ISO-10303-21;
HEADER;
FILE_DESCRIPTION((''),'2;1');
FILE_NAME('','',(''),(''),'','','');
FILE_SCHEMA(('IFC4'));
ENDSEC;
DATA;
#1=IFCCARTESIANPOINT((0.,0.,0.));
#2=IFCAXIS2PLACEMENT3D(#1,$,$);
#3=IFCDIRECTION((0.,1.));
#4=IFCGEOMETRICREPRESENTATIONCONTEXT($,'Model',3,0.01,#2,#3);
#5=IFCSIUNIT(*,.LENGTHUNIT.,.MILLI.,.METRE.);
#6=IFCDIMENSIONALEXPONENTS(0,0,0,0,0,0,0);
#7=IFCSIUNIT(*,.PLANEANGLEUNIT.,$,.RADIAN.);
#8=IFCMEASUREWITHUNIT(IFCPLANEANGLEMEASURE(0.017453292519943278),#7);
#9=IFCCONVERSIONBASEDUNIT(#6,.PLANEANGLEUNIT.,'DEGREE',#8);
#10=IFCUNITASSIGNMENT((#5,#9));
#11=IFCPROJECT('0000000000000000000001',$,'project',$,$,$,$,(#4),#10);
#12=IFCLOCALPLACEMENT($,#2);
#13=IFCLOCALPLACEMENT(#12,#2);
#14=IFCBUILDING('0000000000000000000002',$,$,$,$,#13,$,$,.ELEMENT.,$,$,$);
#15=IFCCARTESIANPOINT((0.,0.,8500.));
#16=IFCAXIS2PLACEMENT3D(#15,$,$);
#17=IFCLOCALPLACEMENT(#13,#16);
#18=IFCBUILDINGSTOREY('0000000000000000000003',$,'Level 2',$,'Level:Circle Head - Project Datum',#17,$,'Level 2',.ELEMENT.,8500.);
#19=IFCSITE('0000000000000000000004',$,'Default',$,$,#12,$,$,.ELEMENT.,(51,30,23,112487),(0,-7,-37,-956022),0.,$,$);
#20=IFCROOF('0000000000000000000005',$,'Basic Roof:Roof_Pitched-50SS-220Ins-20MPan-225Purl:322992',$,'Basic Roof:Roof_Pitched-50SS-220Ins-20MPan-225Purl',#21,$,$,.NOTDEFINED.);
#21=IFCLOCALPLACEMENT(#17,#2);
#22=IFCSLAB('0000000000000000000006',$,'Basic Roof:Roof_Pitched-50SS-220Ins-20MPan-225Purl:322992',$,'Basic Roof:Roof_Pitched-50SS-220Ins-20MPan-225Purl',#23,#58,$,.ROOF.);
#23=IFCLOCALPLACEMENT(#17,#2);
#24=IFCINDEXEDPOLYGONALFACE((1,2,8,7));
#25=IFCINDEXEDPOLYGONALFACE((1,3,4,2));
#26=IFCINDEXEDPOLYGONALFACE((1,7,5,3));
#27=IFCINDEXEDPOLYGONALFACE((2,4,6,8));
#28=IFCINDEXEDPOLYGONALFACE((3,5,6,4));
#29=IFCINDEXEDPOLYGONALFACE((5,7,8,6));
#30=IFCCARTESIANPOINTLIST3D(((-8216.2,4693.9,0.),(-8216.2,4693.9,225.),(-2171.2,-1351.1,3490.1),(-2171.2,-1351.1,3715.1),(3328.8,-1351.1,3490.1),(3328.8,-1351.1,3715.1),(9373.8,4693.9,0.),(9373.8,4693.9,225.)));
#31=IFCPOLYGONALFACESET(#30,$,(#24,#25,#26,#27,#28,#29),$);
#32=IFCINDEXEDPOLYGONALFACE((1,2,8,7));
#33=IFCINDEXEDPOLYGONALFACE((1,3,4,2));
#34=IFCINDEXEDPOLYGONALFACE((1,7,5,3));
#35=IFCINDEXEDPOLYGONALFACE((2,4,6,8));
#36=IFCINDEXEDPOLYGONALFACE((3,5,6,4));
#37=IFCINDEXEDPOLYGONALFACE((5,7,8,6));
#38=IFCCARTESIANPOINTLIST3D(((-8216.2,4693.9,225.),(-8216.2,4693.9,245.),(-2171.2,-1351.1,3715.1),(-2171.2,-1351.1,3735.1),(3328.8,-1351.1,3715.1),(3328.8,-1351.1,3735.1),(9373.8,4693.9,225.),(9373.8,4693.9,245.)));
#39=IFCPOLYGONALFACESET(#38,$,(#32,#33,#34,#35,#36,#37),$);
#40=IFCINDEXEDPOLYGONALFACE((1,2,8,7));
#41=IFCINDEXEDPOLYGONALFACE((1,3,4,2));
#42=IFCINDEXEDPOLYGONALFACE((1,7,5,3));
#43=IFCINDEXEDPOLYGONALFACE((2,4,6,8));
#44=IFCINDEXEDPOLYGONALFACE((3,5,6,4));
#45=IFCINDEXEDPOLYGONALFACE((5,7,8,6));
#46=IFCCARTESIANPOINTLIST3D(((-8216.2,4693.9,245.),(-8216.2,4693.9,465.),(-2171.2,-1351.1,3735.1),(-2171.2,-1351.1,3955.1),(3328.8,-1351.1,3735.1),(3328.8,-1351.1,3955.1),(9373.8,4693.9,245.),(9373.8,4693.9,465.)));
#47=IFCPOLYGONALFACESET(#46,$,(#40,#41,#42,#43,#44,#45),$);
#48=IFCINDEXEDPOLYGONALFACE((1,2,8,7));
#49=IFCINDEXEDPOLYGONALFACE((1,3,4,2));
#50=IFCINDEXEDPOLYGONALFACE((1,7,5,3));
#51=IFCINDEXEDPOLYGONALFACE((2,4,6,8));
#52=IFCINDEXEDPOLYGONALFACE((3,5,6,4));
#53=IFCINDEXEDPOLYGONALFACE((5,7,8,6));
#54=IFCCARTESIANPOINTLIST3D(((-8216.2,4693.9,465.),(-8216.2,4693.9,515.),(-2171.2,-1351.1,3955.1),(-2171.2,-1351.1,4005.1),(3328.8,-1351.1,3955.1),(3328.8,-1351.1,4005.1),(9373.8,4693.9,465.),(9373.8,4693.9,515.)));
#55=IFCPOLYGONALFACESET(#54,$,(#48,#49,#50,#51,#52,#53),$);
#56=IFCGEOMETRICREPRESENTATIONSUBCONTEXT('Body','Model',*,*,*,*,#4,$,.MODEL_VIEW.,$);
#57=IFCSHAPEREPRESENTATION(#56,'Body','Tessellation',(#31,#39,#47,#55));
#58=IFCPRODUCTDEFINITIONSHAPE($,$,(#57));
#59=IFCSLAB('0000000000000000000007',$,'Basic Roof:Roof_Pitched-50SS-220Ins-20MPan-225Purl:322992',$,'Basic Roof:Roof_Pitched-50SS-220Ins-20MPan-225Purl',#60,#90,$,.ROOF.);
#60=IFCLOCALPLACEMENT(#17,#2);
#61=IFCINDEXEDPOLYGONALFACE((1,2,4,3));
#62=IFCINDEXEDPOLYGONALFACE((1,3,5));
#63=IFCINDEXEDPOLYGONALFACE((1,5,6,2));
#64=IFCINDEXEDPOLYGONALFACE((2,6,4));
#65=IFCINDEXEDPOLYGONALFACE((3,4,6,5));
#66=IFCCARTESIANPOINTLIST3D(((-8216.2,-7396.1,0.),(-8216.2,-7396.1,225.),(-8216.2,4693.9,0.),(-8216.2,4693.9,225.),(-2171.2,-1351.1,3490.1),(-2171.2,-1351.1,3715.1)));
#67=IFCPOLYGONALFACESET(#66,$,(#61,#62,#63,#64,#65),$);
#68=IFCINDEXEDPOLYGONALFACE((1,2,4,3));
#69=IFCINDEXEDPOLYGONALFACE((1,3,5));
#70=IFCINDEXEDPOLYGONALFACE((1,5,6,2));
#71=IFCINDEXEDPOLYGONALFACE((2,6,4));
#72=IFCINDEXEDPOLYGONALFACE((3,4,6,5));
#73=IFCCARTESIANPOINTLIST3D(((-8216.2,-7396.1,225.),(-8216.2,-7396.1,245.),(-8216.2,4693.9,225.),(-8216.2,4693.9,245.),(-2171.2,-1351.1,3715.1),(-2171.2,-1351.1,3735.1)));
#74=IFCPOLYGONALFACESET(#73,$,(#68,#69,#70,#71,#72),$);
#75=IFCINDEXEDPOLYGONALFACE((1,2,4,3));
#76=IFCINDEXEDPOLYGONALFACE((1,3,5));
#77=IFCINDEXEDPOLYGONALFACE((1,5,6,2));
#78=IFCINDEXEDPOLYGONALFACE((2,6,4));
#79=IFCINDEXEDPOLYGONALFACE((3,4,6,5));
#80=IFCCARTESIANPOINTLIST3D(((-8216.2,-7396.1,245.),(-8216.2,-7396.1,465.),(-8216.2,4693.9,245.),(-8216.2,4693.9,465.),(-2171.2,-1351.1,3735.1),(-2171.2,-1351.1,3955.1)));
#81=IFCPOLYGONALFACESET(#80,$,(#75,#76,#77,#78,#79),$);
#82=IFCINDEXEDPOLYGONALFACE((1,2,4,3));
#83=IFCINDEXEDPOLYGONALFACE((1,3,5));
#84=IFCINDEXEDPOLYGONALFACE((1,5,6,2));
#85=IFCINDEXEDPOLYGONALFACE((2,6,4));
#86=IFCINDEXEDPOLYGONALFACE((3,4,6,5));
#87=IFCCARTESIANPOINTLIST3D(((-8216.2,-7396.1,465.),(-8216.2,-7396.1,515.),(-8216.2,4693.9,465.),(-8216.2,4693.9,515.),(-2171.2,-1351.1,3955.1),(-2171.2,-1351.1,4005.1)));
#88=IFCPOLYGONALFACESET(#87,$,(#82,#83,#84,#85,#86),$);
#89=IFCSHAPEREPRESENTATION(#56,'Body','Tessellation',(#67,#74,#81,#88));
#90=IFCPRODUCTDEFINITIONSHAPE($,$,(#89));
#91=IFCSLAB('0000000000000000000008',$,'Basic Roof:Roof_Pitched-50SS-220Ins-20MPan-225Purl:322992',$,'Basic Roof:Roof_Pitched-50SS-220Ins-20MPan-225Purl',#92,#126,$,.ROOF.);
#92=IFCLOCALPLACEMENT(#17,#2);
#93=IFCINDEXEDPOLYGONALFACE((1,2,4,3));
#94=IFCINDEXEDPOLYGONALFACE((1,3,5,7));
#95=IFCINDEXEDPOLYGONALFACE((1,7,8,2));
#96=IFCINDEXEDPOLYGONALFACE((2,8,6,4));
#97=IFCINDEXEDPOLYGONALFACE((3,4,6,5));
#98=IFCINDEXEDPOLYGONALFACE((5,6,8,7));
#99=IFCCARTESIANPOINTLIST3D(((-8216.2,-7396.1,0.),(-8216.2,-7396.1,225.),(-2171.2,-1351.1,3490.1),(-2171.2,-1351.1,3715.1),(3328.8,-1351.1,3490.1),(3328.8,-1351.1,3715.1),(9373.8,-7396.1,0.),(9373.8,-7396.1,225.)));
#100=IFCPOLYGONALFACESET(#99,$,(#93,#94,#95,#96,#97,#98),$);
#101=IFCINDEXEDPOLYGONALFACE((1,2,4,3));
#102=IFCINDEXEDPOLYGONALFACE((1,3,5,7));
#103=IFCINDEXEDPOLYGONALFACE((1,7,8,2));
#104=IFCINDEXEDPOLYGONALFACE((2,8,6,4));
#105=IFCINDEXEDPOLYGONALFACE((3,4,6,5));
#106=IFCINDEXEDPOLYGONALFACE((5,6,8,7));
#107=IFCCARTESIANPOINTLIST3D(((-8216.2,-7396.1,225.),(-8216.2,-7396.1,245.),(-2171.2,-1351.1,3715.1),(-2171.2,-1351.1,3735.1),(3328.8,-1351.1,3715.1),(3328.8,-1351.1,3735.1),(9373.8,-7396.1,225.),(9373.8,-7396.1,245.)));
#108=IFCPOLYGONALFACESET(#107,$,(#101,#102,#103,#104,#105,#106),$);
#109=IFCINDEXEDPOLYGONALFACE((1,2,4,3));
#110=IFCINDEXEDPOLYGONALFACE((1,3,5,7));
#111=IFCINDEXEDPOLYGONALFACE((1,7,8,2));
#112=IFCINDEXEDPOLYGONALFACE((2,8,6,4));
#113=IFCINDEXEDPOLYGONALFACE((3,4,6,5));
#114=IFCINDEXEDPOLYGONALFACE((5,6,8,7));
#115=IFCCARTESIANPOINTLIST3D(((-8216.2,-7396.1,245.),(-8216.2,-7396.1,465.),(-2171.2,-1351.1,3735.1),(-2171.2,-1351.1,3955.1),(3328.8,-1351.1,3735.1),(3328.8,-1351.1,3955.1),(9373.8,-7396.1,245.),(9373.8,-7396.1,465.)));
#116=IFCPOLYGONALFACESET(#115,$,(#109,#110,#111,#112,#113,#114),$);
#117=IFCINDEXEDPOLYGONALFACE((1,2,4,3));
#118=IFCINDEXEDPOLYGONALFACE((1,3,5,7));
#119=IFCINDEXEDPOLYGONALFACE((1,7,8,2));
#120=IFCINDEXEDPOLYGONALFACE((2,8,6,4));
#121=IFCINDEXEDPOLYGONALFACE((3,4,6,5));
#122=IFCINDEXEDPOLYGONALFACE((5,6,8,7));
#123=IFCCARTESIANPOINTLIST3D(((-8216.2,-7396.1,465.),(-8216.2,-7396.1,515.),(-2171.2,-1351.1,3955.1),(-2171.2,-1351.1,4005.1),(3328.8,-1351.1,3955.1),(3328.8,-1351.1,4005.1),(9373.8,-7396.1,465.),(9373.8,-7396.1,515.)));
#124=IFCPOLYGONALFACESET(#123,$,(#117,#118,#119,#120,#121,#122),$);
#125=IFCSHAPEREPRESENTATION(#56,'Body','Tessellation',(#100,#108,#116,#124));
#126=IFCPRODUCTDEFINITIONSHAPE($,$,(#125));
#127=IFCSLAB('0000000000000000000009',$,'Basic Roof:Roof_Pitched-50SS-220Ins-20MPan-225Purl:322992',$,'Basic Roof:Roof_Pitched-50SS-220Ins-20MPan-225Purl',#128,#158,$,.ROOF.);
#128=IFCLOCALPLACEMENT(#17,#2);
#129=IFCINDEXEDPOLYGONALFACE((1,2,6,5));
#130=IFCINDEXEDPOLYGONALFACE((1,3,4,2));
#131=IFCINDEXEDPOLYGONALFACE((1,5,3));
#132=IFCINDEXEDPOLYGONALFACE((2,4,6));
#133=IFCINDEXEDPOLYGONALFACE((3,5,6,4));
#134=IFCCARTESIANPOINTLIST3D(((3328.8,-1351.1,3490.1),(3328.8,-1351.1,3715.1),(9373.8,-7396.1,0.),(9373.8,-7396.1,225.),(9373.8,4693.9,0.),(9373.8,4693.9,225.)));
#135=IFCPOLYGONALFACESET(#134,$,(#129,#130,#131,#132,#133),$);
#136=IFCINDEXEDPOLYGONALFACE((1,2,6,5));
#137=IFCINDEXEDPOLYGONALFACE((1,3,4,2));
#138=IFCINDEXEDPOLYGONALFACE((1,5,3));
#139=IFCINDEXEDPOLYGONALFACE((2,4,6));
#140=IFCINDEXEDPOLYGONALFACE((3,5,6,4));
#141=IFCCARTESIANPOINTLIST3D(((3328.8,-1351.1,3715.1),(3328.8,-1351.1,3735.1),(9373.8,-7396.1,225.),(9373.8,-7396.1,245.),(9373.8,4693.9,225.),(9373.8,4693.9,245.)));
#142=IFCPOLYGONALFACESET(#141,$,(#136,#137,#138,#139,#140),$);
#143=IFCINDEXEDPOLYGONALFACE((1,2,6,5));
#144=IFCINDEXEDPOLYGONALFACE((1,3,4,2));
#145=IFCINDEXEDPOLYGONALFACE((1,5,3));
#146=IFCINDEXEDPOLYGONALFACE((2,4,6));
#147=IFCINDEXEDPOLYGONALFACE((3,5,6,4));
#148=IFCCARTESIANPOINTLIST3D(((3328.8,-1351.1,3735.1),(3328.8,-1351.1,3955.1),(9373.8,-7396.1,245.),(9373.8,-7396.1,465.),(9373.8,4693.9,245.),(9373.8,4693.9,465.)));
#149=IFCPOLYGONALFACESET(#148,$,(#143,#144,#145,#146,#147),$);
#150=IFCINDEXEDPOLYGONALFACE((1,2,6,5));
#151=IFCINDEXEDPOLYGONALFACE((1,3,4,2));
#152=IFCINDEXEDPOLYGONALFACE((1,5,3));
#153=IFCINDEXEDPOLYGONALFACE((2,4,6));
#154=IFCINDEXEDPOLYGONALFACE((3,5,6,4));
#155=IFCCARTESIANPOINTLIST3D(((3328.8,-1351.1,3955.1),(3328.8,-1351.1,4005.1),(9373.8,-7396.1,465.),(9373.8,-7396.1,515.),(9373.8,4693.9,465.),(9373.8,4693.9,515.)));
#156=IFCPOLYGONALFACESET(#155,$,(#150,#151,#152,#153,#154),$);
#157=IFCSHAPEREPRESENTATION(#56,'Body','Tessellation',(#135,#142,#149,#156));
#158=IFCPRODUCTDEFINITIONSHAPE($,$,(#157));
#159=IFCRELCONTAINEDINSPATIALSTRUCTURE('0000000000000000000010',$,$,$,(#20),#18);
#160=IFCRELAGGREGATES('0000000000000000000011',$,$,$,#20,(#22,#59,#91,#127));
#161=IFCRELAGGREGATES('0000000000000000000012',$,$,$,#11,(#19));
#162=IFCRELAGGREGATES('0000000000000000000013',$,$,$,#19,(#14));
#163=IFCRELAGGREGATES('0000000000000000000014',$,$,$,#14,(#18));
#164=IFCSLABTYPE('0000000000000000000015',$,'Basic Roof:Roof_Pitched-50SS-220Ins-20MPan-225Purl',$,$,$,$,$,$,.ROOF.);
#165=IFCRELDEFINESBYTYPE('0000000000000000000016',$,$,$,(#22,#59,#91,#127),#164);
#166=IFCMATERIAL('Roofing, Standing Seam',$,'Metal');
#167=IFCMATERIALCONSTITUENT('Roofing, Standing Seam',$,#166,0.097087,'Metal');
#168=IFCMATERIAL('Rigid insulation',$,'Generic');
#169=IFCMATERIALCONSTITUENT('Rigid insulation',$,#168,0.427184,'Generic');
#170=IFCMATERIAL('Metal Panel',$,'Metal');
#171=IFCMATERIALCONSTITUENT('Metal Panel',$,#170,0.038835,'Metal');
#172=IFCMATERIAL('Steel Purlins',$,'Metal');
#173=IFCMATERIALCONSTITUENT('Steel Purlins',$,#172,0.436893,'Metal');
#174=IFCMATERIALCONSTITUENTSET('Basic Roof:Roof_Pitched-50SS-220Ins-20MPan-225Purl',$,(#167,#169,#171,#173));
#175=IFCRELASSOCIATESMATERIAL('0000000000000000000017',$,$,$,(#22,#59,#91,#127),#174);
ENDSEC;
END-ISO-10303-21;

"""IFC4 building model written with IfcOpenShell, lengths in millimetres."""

from ifc_helpers import new_model, entity, si_unit, converted_unit, direction, frame, origin, place, context, subcontext, project, spatial, indexed_curve, outline, extrude, material, constituent, constituent_set, type_object, element, aggregate, save


model = new_model("IFC4")

# Units and contexts
model_context = context("Model", 3, precision=0.01, world=origin(), true_north=direction((0.0, 1.0)))
body_context = subcontext(model_context, "Body", "Model", "MODEL_VIEW")
ifc_project = project(units=[si_unit("LENGTHUNIT", "METRE", prefix="MILLI"), converted_unit("PLANEANGLEUNIT", "DEGREE", entity("IfcPlaneAngleMeasure", 0.017453292519943278), si_unit("PLANEANGLEUNIT", "RADIAN"), dimensions=[0, 0, 0, 0, 0, 0, 0])], contexts=[model_context])

# Site, building, storey
site_placement = place(None, origin())
site = spatial("IfcSite", under=ifc_project, at=site_placement, Name="Default", CompositionType="ELEMENT", RefLatitude=(51, 30, 23, 112487), RefLongitude=(0, -7, -37, -956022), RefElevation=0.0)
building_placement = place(site_placement, origin())
building = spatial("IfcBuilding", under=site, at=building_placement, CompositionType="ELEMENT")
storey_placement = place(building_placement, frame((0.0, 0.0, 8500.0)))
storey = spatial("IfcBuildingStorey", under=building, at=storey_placement, Name="Level 2", ObjectType="Level:Circle Head - Project Datum", LongName="Level 2", CompositionType="ELEMENT", Elevation=8500.0)

# Roof, slabs
roof_placement = place(storey_placement, frame((-8216.2, -7396.1, 0.0)))
roof = element("IfcRoof", 1, at=roof_placement, inside=storey, Name="Basic Roof:Roof_Pitched-50SS-220Ins-20MPan-225Purl:322992", ObjectType="Basic Roof:Roof_Pitched-50SS-220Ins-20MPan-225Purl", PredefinedType="NOTDEFINED")
ifc_material_1 = material(Name="Roofing, Standing Seam", Category="Metal")
ifc_constituent_1 = constituent(ifc_material_1, Name="Roofing, Standing Seam", Category="Metal", fraction=0.097087)
ifc_material_2 = material(Name="Rigid insulation", Category="Generic")
ifc_constituent_2 = constituent(ifc_material_2, Name="Rigid insulation", Category="Generic", fraction=0.427184)
ifc_material_3 = material(Name="Metal Panel", Category="Metal")
ifc_constituent_3 = constituent(ifc_material_3, Name="Metal Panel", Category="Metal", fraction=0.038835)
ifc_material_4 = material(Name="Steel Purlins", Category="Metal")
ifc_constituent_4 = constituent(ifc_material_4, Name="Steel Purlins", Category="Metal", fraction=0.436893)
ifc_constituent_set = constituent_set(constituents=[ifc_constituent_1, ifc_constituent_2, ifc_constituent_3, ifc_constituent_4], Name="Basic Roof:Roof_Pitched-50SS-220Ins-20MPan-225Purl")
slab_type = type_object("IfcSlabType", Name="Basic Roof:Roof_Pitched-50SS-220Ins-20MPan-225Purl", PredefinedType="ROOF")
slab_1_placement = place(roof_placement, origin())
slab_1 = element("IfcSlab", 2, at=slab_1_placement, type_object=slab_type, material=ifc_constituent_set, Name="Basic Roof:Roof_Pitched-50SS-220Ins-20MPan-225Purl:322992", ObjectType="Basic Roof:Roof_Pitched-50SS-220Ins-20MPan-225Purl", PredefinedType="ROOF", context=body_context, shape_type="SweptSolid", body=[
    extrude(outline(indexed_curve([(8795.0, 3490.1), (-8795.0, 3490.1), (-2750.0, -3490.1), (2750.0, -3490.1), (8795.0, 3490.1)], self_intersect=False)), frame((8795.0, 9067.5, 1745.0), z_axis=(0.0, 0.5, 0.866025), x_axis=(1.0, 0.0, 0.0)), (0.0, -0.5, 0.866025), 225.0),
    extrude(outline(indexed_curve([(8795.0, 3490.1), (-8795.0, 3490.1), (-2750.0, -3490.1), (2750.0, -3490.1), (8795.0, 3490.1)], self_intersect=False)), frame((8795.0, 9067.5, 1970.0), z_axis=(0.0, 0.5, 0.866025), x_axis=(1.0, 0.0, 0.0)), (0.0, -0.5, 0.866025), 20.0),
    extrude(outline(indexed_curve([(8795.0, 3490.1), (-8795.0, 3490.1), (-2750.0, -3490.1), (2750.0, -3490.1), (8795.0, 3490.1)], self_intersect=False)), frame((8795.0, 9067.5, 1990.0), z_axis=(0.0, 0.5, 0.866025), x_axis=(1.0, 0.0, 0.0)), (0.0, -0.5, 0.866025), 220.0),
    extrude(outline(indexed_curve([(8795.0, 3490.1), (-8795.0, 3490.1), (-2750.0, -3490.1), (2750.0, -3490.1), (8795.0, 3490.1)], self_intersect=False)), frame((8795.0, 9067.5, 2210.0), z_axis=(0.0, 0.5, 0.866025), x_axis=(1.0, 0.0, 0.0)), (0.0, -0.5, 0.866025), 50.0),
])
slab_2_placement = place(roof_placement, origin())
slab_2 = element("IfcSlab", 3, at=slab_2_placement, type_object=slab_type, material=ifc_constituent_set, Name="Basic Roof:Roof_Pitched-50SS-220Ins-20MPan-225Purl:322992", ObjectType="Basic Roof:Roof_Pitched-50SS-220Ins-20MPan-225Purl", PredefinedType="ROOF", context=body_context, shape_type="SweptSolid", body=[
    extrude(outline(indexed_curve([(-3490.1, 6045.0), (-3490.1, -6045.0), (3490.1, 0.0), (-3490.1, 6045.0)], self_intersect=False)), frame((3022.5, 6045.0, 1745.0), z_axis=(-0.5, 0.0, 0.866025), x_axis=(0.866025, 0.0, 0.5)), (0.5, 0.0, 0.866025), 225.0),
    extrude(outline(indexed_curve([(-3490.1, 6045.0), (-3490.1, -6045.0), (3490.1, 0.0), (-3490.1, 6045.0)], self_intersect=False)), frame((3022.5, 6045.0, 1970.0), z_axis=(-0.5, 0.0, 0.866025), x_axis=(0.866025, 0.0, 0.5)), (0.5, 0.0, 0.866025), 20.0),
    extrude(outline(indexed_curve([(-3490.1, 6045.0), (-3490.1, -6045.0), (3490.1, 0.0), (-3490.1, 6045.0)], self_intersect=False)), frame((3022.5, 6045.0, 1990.0), z_axis=(-0.5, 0.0, 0.866025), x_axis=(0.866025, 0.0, 0.5)), (0.5, 0.0, 0.866025), 220.0),
    extrude(outline(indexed_curve([(-3490.1, 6045.0), (-3490.1, -6045.0), (3490.1, 0.0), (-3490.1, 6045.0)], self_intersect=False)), frame((3022.5, 6045.0, 2210.0), z_axis=(-0.5, 0.0, 0.866025), x_axis=(0.866025, 0.0, 0.5)), (0.5, 0.0, 0.866025), 50.0),
])
slab_3_placement = place(roof_placement, origin())
slab_3 = element("IfcSlab", 4, at=slab_3_placement, type_object=slab_type, material=ifc_constituent_set, Name="Basic Roof:Roof_Pitched-50SS-220Ins-20MPan-225Purl:322992", ObjectType="Basic Roof:Roof_Pitched-50SS-220Ins-20MPan-225Purl", PredefinedType="ROOF", context=body_context, shape_type="SweptSolid", body=[
    extrude(outline(indexed_curve([(-8795.0, -3490.1), (8795.0, -3490.1), (2750.0, 3490.1), (-2750.0, 3490.1), (-8795.0, -3490.1)], self_intersect=False)), frame((8795.0, 3022.5, 1745.0), z_axis=(0.0, -0.5, 0.866025), x_axis=(1.0, 0.0, 0.0)), (0.0, 0.5, 0.866025), 225.0),
    extrude(outline(indexed_curve([(-8795.0, -3490.1), (8795.0, -3490.1), (2750.0, 3490.1), (-2750.0, 3490.1), (-8795.0, -3490.1)], self_intersect=False)), frame((8795.0, 3022.5, 1970.0), z_axis=(0.0, -0.5, 0.866025), x_axis=(1.0, 0.0, 0.0)), (0.0, 0.5, 0.866025), 20.0),
    extrude(outline(indexed_curve([(-8795.0, -3490.1), (8795.0, -3490.1), (2750.0, 3490.1), (-2750.0, 3490.1), (-8795.0, -3490.1)], self_intersect=False)), frame((8795.0, 3022.5, 1990.0), z_axis=(0.0, -0.5, 0.866025), x_axis=(1.0, 0.0, 0.0)), (0.0, 0.5, 0.866025), 220.0),
    extrude(outline(indexed_curve([(-8795.0, -3490.1), (8795.0, -3490.1), (2750.0, 3490.1), (-2750.0, 3490.1), (-8795.0, -3490.1)], self_intersect=False)), frame((8795.0, 3022.5, 2210.0), z_axis=(0.0, -0.5, 0.866025), x_axis=(1.0, 0.0, 0.0)), (0.0, 0.5, 0.866025), 50.0),
])
slab_4_placement = place(roof_placement, origin())
slab_4 = element("IfcSlab", 5, at=slab_4_placement, type_object=slab_type, material=ifc_constituent_set, Name="Basic Roof:Roof_Pitched-50SS-220Ins-20MPan-225Purl:322992", ObjectType="Basic Roof:Roof_Pitched-50SS-220Ins-20MPan-225Purl", PredefinedType="ROOF", context=body_context, shape_type="SweptSolid", body=[
    extrude(outline(indexed_curve([(-3490.1, 0.0), (3490.1, -6045.0), (3490.1, 6045.0), (-3490.1, 0.0)], self_intersect=False)), frame((14567.5, 6045.0, 1745.0), z_axis=(0.5, 0.0, 0.866025), x_axis=(0.866025, 0.0, -0.5)), (-0.5, 0.0, 0.866025), 225.0),
    extrude(outline(indexed_curve([(-3490.1, 0.0), (3490.1, -6045.0), (3490.1, 6045.0), (-3490.1, 0.0)], self_intersect=False)), frame((14567.5, 6045.0, 1970.0), z_axis=(0.5, 0.0, 0.866025), x_axis=(0.866025, 0.0, -0.5)), (-0.5, 0.0, 0.866025), 20.0),
    extrude(outline(indexed_curve([(-3490.1, 0.0), (3490.1, -6045.0), (3490.1, 6045.0), (-3490.1, 0.0)], self_intersect=False)), frame((14567.5, 6045.0, 1990.0), z_axis=(0.5, 0.0, 0.866025), x_axis=(0.866025, 0.0, -0.5)), (-0.5, 0.0, 0.866025), 220.0),
    extrude(outline(indexed_curve([(-3490.1, 0.0), (3490.1, -6045.0), (3490.1, 6045.0), (-3490.1, 0.0)], self_intersect=False)), frame((14567.5, 6045.0, 2210.0), z_axis=(0.5, 0.0, 0.866025), x_axis=(0.866025, 0.0, -0.5)), (-0.5, 0.0, 0.866025), 50.0),
])
aggregate(roof, [slab_1, slab_2, slab_3, slab_4])

save(model, "model.ifc")
